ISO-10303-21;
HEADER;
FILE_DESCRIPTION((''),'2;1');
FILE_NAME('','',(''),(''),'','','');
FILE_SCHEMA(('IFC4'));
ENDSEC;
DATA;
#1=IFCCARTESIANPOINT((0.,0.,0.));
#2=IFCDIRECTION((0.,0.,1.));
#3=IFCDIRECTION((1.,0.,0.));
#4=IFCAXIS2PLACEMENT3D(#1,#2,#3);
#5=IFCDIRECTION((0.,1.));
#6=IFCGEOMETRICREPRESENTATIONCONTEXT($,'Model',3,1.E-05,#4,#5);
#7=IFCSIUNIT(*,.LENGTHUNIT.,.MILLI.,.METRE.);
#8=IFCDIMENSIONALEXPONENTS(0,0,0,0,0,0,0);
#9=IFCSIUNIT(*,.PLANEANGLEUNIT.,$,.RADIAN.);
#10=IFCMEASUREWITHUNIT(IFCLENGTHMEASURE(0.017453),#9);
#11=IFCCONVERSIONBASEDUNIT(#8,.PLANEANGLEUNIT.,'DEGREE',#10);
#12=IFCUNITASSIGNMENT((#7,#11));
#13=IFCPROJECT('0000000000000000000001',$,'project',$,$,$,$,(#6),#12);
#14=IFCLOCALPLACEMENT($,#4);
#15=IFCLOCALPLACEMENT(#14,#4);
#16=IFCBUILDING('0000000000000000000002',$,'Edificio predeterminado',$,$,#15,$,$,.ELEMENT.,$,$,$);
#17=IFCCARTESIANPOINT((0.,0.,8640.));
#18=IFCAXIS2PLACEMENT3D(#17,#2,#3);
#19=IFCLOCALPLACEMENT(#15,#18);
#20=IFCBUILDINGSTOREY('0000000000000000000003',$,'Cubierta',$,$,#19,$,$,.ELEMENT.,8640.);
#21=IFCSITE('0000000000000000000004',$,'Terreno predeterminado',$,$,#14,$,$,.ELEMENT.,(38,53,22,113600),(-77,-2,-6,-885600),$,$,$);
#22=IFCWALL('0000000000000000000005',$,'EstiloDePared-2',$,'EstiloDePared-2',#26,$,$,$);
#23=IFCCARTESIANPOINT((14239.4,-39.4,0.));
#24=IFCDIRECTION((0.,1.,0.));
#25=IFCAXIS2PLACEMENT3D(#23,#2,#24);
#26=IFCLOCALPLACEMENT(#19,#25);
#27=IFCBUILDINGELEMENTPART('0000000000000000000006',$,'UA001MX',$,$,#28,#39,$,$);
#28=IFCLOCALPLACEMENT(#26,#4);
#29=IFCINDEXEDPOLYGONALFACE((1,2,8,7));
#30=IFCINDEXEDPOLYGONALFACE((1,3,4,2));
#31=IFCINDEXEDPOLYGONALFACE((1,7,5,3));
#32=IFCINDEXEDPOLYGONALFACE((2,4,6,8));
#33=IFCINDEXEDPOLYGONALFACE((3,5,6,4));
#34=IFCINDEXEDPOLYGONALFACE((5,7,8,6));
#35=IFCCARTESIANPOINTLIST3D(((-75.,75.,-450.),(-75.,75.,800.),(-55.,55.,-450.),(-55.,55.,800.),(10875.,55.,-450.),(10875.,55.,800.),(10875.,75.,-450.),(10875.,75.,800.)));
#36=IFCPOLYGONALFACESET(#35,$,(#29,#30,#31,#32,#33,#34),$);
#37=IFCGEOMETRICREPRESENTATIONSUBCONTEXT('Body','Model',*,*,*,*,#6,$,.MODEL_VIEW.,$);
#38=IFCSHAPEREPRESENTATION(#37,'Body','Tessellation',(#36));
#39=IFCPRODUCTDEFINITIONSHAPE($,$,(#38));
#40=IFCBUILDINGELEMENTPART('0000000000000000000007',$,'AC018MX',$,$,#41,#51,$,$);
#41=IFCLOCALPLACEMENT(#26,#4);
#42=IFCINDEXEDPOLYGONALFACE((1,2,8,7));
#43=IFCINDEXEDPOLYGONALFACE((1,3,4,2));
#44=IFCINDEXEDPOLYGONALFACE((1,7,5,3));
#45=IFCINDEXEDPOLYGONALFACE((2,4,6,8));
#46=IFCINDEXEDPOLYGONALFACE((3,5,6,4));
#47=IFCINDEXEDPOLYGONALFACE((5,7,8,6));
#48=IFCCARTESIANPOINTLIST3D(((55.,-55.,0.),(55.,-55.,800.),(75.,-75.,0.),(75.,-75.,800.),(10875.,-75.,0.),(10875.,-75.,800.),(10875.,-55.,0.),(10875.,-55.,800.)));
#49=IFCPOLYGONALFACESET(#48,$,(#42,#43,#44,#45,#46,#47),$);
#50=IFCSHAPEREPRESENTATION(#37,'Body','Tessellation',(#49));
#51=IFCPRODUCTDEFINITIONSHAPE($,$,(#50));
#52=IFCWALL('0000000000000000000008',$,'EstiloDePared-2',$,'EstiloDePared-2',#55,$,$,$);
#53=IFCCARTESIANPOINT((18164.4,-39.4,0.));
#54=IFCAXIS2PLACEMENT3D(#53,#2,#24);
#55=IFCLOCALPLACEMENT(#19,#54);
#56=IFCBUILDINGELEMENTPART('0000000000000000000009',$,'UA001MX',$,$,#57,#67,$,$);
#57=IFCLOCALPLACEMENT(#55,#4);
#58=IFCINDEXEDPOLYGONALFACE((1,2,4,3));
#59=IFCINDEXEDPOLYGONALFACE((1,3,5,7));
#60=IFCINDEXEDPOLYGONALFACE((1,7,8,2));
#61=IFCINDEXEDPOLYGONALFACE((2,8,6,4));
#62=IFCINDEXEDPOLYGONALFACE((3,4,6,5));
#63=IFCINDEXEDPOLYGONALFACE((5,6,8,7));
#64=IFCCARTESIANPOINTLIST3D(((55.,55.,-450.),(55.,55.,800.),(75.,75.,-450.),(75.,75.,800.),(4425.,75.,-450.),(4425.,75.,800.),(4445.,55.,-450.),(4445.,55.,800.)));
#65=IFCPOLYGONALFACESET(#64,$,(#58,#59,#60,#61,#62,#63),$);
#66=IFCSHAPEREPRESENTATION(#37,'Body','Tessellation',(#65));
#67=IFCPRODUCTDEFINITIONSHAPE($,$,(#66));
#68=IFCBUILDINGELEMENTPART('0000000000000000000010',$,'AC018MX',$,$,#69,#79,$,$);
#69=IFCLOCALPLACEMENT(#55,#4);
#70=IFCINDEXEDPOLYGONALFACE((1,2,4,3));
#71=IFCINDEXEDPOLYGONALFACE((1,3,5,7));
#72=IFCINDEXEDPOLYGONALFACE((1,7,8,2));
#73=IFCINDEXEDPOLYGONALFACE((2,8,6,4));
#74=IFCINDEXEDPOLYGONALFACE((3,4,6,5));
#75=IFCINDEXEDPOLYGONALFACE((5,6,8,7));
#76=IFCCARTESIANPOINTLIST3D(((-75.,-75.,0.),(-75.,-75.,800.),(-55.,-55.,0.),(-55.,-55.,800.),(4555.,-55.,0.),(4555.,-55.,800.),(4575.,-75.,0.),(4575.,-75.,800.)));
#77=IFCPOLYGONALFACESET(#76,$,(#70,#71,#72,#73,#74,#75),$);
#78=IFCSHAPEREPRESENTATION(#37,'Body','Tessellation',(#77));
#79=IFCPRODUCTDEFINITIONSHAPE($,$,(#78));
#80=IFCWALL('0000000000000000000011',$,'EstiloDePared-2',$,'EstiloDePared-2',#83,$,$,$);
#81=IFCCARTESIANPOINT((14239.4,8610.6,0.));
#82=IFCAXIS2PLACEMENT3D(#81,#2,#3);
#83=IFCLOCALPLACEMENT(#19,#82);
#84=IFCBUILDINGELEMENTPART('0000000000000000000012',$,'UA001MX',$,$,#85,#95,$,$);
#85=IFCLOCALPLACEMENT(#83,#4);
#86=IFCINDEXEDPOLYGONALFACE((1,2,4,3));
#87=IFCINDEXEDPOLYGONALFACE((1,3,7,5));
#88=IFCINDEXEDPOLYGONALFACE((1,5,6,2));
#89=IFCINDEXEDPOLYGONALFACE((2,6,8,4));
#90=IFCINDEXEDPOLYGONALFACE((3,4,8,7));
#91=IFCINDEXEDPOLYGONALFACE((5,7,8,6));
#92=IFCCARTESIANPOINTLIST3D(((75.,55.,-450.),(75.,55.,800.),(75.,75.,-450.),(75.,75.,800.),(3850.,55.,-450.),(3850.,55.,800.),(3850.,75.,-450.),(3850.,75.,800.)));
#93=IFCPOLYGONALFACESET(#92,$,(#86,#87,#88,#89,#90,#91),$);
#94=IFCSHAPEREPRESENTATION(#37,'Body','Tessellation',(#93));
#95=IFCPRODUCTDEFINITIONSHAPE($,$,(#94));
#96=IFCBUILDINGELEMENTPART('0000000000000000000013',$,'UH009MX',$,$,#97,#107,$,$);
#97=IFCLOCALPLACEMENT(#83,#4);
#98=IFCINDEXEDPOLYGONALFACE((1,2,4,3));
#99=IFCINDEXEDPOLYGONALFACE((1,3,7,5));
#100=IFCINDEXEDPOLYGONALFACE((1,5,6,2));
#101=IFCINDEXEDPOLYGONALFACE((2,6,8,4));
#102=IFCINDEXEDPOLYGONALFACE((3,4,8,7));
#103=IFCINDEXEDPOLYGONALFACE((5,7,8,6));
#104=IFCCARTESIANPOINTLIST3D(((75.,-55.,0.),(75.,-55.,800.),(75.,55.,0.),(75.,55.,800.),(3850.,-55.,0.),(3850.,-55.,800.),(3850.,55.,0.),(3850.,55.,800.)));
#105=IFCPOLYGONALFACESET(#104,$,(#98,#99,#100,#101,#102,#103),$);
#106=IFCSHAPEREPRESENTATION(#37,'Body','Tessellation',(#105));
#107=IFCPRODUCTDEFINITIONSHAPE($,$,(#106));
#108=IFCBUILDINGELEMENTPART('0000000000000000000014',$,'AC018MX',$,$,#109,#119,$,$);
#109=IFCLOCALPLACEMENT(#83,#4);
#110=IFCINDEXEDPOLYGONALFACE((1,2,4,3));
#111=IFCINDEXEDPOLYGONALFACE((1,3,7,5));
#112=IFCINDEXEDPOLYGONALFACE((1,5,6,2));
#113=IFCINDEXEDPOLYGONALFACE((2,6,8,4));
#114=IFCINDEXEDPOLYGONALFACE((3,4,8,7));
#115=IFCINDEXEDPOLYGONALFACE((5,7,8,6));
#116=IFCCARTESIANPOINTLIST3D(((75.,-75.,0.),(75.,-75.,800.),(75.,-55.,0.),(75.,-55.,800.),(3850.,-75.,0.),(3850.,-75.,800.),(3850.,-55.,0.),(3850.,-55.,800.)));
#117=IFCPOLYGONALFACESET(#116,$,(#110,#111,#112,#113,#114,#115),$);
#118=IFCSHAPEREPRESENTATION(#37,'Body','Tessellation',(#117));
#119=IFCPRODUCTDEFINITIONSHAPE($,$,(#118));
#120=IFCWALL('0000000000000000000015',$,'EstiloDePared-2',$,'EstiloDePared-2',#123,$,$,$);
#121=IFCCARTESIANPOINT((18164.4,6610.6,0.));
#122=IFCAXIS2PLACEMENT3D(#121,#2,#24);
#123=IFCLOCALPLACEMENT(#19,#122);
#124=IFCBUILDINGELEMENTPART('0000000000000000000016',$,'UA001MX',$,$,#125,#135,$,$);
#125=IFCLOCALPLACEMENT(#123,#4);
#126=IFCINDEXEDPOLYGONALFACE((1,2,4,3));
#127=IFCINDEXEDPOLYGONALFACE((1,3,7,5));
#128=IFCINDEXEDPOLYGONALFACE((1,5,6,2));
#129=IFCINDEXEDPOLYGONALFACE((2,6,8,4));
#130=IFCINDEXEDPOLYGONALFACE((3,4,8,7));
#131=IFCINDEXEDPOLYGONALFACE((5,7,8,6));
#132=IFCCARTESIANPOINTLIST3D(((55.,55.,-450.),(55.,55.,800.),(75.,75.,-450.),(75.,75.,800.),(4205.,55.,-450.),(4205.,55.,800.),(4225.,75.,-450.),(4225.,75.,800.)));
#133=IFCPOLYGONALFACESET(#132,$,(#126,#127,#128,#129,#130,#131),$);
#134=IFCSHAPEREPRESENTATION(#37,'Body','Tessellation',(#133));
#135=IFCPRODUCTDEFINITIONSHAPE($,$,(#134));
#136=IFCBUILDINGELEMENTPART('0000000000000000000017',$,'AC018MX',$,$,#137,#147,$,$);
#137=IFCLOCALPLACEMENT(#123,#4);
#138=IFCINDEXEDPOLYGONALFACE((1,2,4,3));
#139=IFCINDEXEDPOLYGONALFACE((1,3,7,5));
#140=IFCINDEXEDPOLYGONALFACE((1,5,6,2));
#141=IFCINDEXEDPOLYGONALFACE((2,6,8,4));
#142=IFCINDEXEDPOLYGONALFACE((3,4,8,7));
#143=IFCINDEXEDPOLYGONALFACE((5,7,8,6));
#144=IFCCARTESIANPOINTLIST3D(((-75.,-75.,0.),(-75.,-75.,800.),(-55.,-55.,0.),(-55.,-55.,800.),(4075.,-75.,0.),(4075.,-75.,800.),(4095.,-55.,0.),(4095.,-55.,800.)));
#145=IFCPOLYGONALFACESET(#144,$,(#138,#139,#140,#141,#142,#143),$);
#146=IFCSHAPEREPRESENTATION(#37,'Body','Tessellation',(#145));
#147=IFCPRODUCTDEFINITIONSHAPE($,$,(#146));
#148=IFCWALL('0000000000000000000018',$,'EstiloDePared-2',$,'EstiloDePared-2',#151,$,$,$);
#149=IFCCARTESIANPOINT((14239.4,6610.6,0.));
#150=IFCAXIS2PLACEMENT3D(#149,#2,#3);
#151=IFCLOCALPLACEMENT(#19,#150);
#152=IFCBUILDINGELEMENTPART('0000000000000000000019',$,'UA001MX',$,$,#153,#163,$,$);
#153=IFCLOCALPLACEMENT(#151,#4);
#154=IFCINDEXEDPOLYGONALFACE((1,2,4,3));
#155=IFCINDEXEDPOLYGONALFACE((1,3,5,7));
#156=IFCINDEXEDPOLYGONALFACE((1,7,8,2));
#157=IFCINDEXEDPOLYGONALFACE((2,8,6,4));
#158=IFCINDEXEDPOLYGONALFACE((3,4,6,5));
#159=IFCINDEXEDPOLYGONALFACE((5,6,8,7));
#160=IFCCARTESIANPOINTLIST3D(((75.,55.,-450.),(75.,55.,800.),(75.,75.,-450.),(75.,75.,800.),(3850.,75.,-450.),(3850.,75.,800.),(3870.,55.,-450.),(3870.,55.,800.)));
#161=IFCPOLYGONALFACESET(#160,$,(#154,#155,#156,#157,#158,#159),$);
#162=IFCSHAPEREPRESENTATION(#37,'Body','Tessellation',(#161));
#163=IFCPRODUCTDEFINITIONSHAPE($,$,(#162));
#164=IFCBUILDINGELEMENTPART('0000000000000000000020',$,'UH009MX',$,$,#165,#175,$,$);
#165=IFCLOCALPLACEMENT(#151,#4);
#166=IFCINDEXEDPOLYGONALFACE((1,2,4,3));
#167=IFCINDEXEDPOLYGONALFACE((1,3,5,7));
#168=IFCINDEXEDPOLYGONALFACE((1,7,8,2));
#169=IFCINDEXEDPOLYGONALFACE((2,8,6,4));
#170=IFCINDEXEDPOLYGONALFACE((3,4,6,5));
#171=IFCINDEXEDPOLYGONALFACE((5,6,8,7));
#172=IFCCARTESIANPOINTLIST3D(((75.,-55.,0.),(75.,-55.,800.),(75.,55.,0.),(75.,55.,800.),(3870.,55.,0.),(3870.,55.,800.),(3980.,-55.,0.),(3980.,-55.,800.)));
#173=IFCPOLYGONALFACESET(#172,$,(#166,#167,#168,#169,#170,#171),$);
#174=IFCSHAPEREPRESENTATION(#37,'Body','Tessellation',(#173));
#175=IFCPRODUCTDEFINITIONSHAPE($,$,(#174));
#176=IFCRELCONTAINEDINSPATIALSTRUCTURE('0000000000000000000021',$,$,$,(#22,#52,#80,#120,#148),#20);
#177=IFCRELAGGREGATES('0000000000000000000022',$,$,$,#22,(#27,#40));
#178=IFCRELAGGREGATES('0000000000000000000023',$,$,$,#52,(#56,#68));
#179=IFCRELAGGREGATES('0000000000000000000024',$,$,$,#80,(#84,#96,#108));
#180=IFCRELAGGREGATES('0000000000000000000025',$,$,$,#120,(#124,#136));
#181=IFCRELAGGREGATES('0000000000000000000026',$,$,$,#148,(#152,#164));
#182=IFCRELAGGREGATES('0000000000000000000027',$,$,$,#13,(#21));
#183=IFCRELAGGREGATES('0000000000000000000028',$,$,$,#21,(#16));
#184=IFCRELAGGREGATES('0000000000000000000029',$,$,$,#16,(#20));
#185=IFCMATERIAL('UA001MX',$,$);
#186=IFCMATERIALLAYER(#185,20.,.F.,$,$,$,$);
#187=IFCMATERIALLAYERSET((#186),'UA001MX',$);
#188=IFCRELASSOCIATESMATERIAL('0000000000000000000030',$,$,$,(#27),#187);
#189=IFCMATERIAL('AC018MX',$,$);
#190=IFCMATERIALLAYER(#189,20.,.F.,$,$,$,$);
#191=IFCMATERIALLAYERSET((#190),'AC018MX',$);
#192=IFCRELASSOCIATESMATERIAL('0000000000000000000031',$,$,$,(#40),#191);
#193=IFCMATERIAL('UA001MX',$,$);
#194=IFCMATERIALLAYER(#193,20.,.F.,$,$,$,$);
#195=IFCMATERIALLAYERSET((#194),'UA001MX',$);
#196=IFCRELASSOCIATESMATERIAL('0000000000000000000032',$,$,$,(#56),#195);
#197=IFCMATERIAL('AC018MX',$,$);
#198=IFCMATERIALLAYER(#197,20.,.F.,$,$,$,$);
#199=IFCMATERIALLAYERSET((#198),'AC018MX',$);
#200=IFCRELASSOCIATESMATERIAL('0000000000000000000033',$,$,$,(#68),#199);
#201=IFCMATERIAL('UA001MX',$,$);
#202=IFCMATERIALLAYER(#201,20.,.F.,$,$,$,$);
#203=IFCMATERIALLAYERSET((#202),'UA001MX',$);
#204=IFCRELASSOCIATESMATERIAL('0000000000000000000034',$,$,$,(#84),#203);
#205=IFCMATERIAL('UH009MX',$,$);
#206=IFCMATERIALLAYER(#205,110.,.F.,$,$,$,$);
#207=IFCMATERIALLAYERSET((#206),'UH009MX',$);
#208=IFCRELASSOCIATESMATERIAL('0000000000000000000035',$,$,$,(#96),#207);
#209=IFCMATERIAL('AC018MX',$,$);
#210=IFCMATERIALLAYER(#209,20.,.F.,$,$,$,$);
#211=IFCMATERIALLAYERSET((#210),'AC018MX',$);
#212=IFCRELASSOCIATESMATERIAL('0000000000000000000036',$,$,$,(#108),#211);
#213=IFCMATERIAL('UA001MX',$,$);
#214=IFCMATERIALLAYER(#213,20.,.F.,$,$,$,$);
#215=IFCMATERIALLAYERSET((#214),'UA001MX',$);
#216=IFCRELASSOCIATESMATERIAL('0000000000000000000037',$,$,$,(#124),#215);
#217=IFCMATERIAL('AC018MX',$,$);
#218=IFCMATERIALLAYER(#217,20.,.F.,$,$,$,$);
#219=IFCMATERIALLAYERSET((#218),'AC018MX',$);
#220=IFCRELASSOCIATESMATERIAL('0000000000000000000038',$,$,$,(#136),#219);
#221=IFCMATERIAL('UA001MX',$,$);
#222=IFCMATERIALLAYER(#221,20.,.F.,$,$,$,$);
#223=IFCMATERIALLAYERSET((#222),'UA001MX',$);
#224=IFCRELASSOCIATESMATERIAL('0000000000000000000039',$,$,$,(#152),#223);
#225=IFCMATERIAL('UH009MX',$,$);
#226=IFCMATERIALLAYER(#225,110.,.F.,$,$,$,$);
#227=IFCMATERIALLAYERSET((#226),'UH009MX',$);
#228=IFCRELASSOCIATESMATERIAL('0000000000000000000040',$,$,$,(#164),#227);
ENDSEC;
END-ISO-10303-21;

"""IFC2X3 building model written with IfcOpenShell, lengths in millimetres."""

from ifc_helpers import new_model, entity, si_unit, converted_unit, direction, frame, origin_with_axes, place, context, subcontext, project, spatial, polyline, outline, extrude, material, layer, layer_set, layer_usage, element, aggregate, save


model = new_model("IFC2X3")

# Units and contexts
model_context = context("Model", 3, precision=1e-05, world=origin_with_axes(), true_north=direction((0.0, 1.0)))
body_context = subcontext(model_context, "Body", "Model", "MODEL_VIEW")
ifc_project = project(units=[si_unit("LENGTHUNIT", "METRE", prefix="MILLI"), converted_unit("PLANEANGLEUNIT", "DEGREE", entity("IfcLengthMeasure", 0.017453), si_unit("PLANEANGLEUNIT", "RADIAN"), dimensions=[0, 0, 0, 0, 0, 0, 0])], contexts=[model_context])

# Site, building, storey
site_placement = place(None, origin_with_axes())
site = spatial("IfcSite", under=ifc_project, at=site_placement, Name="Terreno predeterminado", CompositionType="ELEMENT", RefLatitude=(38, 53, 22, 113600), RefLongitude=(-77, -2, -6, -885600))
building_placement = place(site_placement, origin_with_axes())
building = spatial("IfcBuilding", under=site, at=building_placement, Name="Edificio predeterminado", CompositionType="ELEMENT")
storey_placement = place(building_placement, frame((0.0, 0.0, 8640.0), z_axis=(0.0, 0.0, 1.0), x_axis=(1.0, 0.0, 0.0)))
storey = spatial("IfcBuildingStorey", under=building, at=storey_placement, Name="Cubierta", CompositionType="ELEMENT", Elevation=8640.0)

# Walls, building element parts
wall_1_placement = place(storey_placement, frame((14239.4, -39.4, 0.0), z_axis=(0.0, 0.0, 1.0), x_axis=(0.0, 1.0, 0.0)))
wall_1 = element("IfcWall", 1, at=wall_1_placement, inside=storey, Name="EstiloDePared-2", ObjectType="EstiloDePared-2")
ifc_material_1 = material(Name="UA001MX")
ifc_layer_1 = layer(ifc_material_1, 20.0, ventilated=False)
ifc_layer_set_1 = layer_set([ifc_layer_1], Name="UA001MX")
ifc_layer_usage_1 = layer_usage(ifc_layer_set_1, "AXIS2", "NEGATIVE", -75.0)
building_element_part_1_placement = place(wall_1_placement, origin_with_axes())
building_element_part_1 = element("IfcBuildingElementPart", 2, at=building_element_part_1_placement, material=ifc_layer_usage_1, Name="UA001MX", context=body_context, shape_type="SweptSolid", body=[
    extrude(outline(polyline([(10875.0, 75.0), (10875.0, 55.0), (-55.0, 55.0), (-75.0, 75.0), (10875.0, 75.0)])), frame((0.0, 0.0, -450.0), z_axis=(0.0, 0.0, 1.0), x_axis=(1.0, 0.0, 0.0)), (0.0, 0.0, 1.0), 1250.0),
])
ifc_material_2 = material(Name="AC018MX")
ifc_layer_2 = layer(ifc_material_2, 20.0, ventilated=False)
ifc_layer_set_2 = layer_set([ifc_layer_2], Name="AC018MX")
ifc_layer_usage_2 = layer_usage(ifc_layer_set_2, "AXIS2", "NEGATIVE", 55.0)
building_element_part_2_placement = place(wall_1_placement, origin_with_axes())
building_element_part_2 = element("IfcBuildingElementPart", 3, at=building_element_part_2_placement, material=ifc_layer_usage_2, Name="AC018MX", context=body_context, shape_type="SweptSolid", body=[
    extrude(outline(polyline([(10875.0, -55.0), (10875.0, -75.0), (75.0, -75.0), (55.0, -55.0), (10875.0, -55.0)])), origin_with_axes(), (0.0, 0.0, 1.0), 800.0),
])
aggregate(wall_1, [building_element_part_1, building_element_part_2])
wall_2_placement = place(storey_placement, frame((18164.4, -39.4, 0.0), z_axis=(0.0, 0.0, 1.0), x_axis=(0.0, 1.0, 0.0)))
wall_2 = element("IfcWall", 4, at=wall_2_placement, inside=storey, Name="EstiloDePared-2", ObjectType="EstiloDePared-2")
ifc_material_3 = material(Name="UA001MX")
ifc_layer_3 = layer(ifc_material_3, 20.0, ventilated=False)
ifc_layer_set_3 = layer_set([ifc_layer_3], Name="UA001MX")
ifc_layer_usage_3 = layer_usage(ifc_layer_set_3, "AXIS2", "NEGATIVE", -75.0)
building_element_part_3_placement = place(wall_2_placement, origin_with_axes())
building_element_part_3 = element("IfcBuildingElementPart", 5, at=building_element_part_3_placement, material=ifc_layer_usage_3, Name="UA001MX", context=body_context, shape_type="SweptSolid", body=[
    extrude(outline(polyline([(4425.0, 75.0), (4445.0, 55.0), (55.0, 55.0), (75.0, 75.0), (4425.0, 75.0)])), frame((0.0, 0.0, -450.0), z_axis=(0.0, 0.0, 1.0), x_axis=(1.0, 0.0, 0.0)), (0.0, 0.0, 1.0), 1250.0),
])
ifc_material_4 = material(Name="AC018MX")
ifc_layer_4 = layer(ifc_material_4, 20.0, ventilated=False)
ifc_layer_set_4 = layer_set([ifc_layer_4], Name="AC018MX")
ifc_layer_usage_4 = layer_usage(ifc_layer_set_4, "AXIS2", "NEGATIVE", 55.0)
building_element_part_4_placement = place(wall_2_placement, origin_with_axes())
building_element_part_4 = element("IfcBuildingElementPart", 6, at=building_element_part_4_placement, material=ifc_layer_usage_4, Name="AC018MX", context=body_context, shape_type="SweptSolid", body=[
    extrude(outline(polyline([(4555.0, -55.0), (4575.0, -75.0), (-75.0, -75.0), (-55.0, -55.0), (4555.0, -55.0)])), origin_with_axes(), (0.0, 0.0, 1.0), 800.0),
])
aggregate(wall_2, [building_element_part_3, building_element_part_4])
wall_3_placement = place(storey_placement, frame((14239.4, 8610.6, 0.0), z_axis=(0.0, 0.0, 1.0), x_axis=(1.0, 0.0, 0.0)))
wall_3 = element("IfcWall", 7, at=wall_3_placement, inside=storey, Name="EstiloDePared-2", ObjectType="EstiloDePared-2")
ifc_material_5 = material(Name="UA001MX")
ifc_layer_5 = layer(ifc_material_5, 20.0, ventilated=False)
ifc_layer_set_5 = layer_set([ifc_layer_5], Name="UA001MX")
ifc_layer_usage_5 = layer_usage(ifc_layer_set_5, "AXIS2", "NEGATIVE", -75.0)
building_element_part_5_placement = place(wall_3_placement, origin_with_axes())
building_element_part_5 = element("IfcBuildingElementPart", 8, at=building_element_part_5_placement, material=ifc_layer_usage_5, Name="UA001MX", context=body_context, shape_type="SweptSolid", body=[
    extrude(outline(polyline([(3850.0, 75.0), (3850.0, 55.0), (75.0, 55.0), (75.0, 75.0), (3850.0, 75.0)])), frame((0.0, 0.0, -450.0), z_axis=(0.0, 0.0, 1.0), x_axis=(1.0, 0.0, 0.0)), (0.0, 0.0, 1.0), 1250.0),
])
ifc_material_6 = material(Name="UH009MX")
ifc_layer_6 = layer(ifc_material_6, 110.0, ventilated=False)
ifc_layer_set_6 = layer_set([ifc_layer_6], Name="UH009MX")
ifc_layer_usage_6 = layer_usage(ifc_layer_set_6, "AXIS2", "NEGATIVE", -55.0)
building_element_part_6_placement = place(wall_3_placement, origin_with_axes())
building_element_part_6 = element("IfcBuildingElementPart", 9, at=building_element_part_6_placement, material=ifc_layer_usage_6, Name="UH009MX", context=body_context, shape_type="SweptSolid", body=[
    extrude(outline(polyline([(3850.0, 55.0), (3850.0, -55.0), (75.0, -55.0), (75.0, 55.0), (3850.0, 55.0)])), origin_with_axes(), (0.0, 0.0, 1.0), 800.0),
])
ifc_material_7 = material(Name="AC018MX")
ifc_layer_7 = layer(ifc_material_7, 20.0, ventilated=False)
ifc_layer_set_7 = layer_set([ifc_layer_7], Name="AC018MX")
ifc_layer_usage_7 = layer_usage(ifc_layer_set_7, "AXIS2", "NEGATIVE", 55.0)
building_element_part_7_placement = place(wall_3_placement, origin_with_axes())
building_element_part_7 = element("IfcBuildingElementPart", 10, at=building_element_part_7_placement, material=ifc_layer_usage_7, Name="AC018MX", context=body_context, shape_type="SweptSolid", body=[
    extrude(outline(polyline([(3850.0, -55.0), (3850.0, -75.0), (75.0, -75.0), (75.0, -55.0), (3850.0, -55.0)])), origin_with_axes(), (0.0, 0.0, 1.0), 800.0),
])
aggregate(wall_3, [building_element_part_5, building_element_part_6, building_element_part_7])
wall_4_placement = place(storey_placement, frame((18164.4, 6610.6, 0.0), z_axis=(0.0, 0.0, 1.0), x_axis=(0.0, 1.0, 0.0)))
wall_4 = element("IfcWall", 11, at=wall_4_placement, inside=storey, Name="EstiloDePared-2", ObjectType="EstiloDePared-2")
ifc_material_8 = material(Name="UA001MX")
ifc_layer_8 = layer(ifc_material_8, 20.0, ventilated=False)
ifc_layer_set_8 = layer_set([ifc_layer_8], Name="UA001MX")
ifc_layer_usage_8 = layer_usage(ifc_layer_set_8, "AXIS2", "NEGATIVE", -75.0)
building_element_part_8_placement = place(wall_4_placement, origin_with_axes())
building_element_part_8 = element("IfcBuildingElementPart", 12, at=building_element_part_8_placement, material=ifc_layer_usage_8, Name="UA001MX", context=body_context, shape_type="SweptSolid", body=[
    extrude(outline(polyline([(4225.0, 75.0), (4205.0, 55.0), (55.0, 55.0), (75.0, 75.0), (4225.0, 75.0)])), frame((0.0, 0.0, -450.0), z_axis=(0.0, 0.0, 1.0), x_axis=(1.0, 0.0, 0.0)), (0.0, 0.0, 1.0), 1250.0),
])
ifc_material_9 = material(Name="AC018MX")
ifc_layer_9 = layer(ifc_material_9, 20.0, ventilated=False)
ifc_layer_set_9 = layer_set([ifc_layer_9], Name="AC018MX")
ifc_layer_usage_9 = layer_usage(ifc_layer_set_9, "AXIS2", "NEGATIVE", 55.0)
building_element_part_9_placement = place(wall_4_placement, origin_with_axes())
building_element_part_9 = element("IfcBuildingElementPart", 13, at=building_element_part_9_placement, material=ifc_layer_usage_9, Name="AC018MX", context=body_context, shape_type="SweptSolid", body=[
    extrude(outline(polyline([(4095.0, -55.0), (4075.0, -75.0), (-75.0, -75.0), (-55.0, -55.0), (4095.0, -55.0)])), origin_with_axes(), (0.0, 0.0, 1.0), 800.0),
])
aggregate(wall_4, [building_element_part_8, building_element_part_9])
wall_5_placement = place(storey_placement, frame((14239.4, 6610.6, 0.0), z_axis=(0.0, 0.0, 1.0), x_axis=(1.0, 0.0, 0.0)))
wall_5 = element("IfcWall", 14, at=wall_5_placement, inside=storey, Name="EstiloDePared-2", ObjectType="EstiloDePared-2")
ifc_material_10 = material(Name="UA001MX")
ifc_layer_10 = layer(ifc_material_10, 20.0, ventilated=False)
ifc_layer_set_10 = layer_set([ifc_layer_10], Name="UA001MX")
ifc_layer_usage_10 = layer_usage(ifc_layer_set_10, "AXIS2", "NEGATIVE", -75.0)
building_element_part_10_placement = place(wall_5_placement, origin_with_axes())
building_element_part_10 = element("IfcBuildingElementPart", 15, at=building_element_part_10_placement, material=ifc_layer_usage_10, Name="UA001MX", context=body_context, shape_type="SweptSolid", body=[
    extrude(outline(polyline([(3850.0, 75.0), (3870.0, 55.0), (75.0, 55.0), (75.0, 75.0), (3850.0, 75.0)])), frame((0.0, 0.0, -450.0), z_axis=(0.0, 0.0, 1.0), x_axis=(1.0, 0.0, 0.0)), (0.0, 0.0, 1.0), 1250.0),
])
ifc_material_11 = material(Name="UH009MX")
ifc_layer_11 = layer(ifc_material_11, 110.0, ventilated=False)
ifc_layer_set_11 = layer_set([ifc_layer_11], Name="UH009MX")
ifc_layer_usage_11 = layer_usage(ifc_layer_set_11, "AXIS2", "NEGATIVE", -55.0)
building_element_part_11_placement = place(wall_5_placement, origin_with_axes())
building_element_part_11 = element("IfcBuildingElementPart", 16, at=building_element_part_11_placement, material=ifc_layer_usage_11, Name="UH009MX", context=body_context, shape_type="SweptSolid", body=[
    extrude(outline(polyline([(3870.0, 55.0), (3980.0, -55.0), (75.0, -55.0), (75.0, 55.0), (3870.0, 55.0)])), origin_with_axes(), (0.0, 0.0, 1.0), 800.0),
])
aggregate(wall_5, [building_element_part_10, building_element_part_11])

save(model, "model.ifc")
